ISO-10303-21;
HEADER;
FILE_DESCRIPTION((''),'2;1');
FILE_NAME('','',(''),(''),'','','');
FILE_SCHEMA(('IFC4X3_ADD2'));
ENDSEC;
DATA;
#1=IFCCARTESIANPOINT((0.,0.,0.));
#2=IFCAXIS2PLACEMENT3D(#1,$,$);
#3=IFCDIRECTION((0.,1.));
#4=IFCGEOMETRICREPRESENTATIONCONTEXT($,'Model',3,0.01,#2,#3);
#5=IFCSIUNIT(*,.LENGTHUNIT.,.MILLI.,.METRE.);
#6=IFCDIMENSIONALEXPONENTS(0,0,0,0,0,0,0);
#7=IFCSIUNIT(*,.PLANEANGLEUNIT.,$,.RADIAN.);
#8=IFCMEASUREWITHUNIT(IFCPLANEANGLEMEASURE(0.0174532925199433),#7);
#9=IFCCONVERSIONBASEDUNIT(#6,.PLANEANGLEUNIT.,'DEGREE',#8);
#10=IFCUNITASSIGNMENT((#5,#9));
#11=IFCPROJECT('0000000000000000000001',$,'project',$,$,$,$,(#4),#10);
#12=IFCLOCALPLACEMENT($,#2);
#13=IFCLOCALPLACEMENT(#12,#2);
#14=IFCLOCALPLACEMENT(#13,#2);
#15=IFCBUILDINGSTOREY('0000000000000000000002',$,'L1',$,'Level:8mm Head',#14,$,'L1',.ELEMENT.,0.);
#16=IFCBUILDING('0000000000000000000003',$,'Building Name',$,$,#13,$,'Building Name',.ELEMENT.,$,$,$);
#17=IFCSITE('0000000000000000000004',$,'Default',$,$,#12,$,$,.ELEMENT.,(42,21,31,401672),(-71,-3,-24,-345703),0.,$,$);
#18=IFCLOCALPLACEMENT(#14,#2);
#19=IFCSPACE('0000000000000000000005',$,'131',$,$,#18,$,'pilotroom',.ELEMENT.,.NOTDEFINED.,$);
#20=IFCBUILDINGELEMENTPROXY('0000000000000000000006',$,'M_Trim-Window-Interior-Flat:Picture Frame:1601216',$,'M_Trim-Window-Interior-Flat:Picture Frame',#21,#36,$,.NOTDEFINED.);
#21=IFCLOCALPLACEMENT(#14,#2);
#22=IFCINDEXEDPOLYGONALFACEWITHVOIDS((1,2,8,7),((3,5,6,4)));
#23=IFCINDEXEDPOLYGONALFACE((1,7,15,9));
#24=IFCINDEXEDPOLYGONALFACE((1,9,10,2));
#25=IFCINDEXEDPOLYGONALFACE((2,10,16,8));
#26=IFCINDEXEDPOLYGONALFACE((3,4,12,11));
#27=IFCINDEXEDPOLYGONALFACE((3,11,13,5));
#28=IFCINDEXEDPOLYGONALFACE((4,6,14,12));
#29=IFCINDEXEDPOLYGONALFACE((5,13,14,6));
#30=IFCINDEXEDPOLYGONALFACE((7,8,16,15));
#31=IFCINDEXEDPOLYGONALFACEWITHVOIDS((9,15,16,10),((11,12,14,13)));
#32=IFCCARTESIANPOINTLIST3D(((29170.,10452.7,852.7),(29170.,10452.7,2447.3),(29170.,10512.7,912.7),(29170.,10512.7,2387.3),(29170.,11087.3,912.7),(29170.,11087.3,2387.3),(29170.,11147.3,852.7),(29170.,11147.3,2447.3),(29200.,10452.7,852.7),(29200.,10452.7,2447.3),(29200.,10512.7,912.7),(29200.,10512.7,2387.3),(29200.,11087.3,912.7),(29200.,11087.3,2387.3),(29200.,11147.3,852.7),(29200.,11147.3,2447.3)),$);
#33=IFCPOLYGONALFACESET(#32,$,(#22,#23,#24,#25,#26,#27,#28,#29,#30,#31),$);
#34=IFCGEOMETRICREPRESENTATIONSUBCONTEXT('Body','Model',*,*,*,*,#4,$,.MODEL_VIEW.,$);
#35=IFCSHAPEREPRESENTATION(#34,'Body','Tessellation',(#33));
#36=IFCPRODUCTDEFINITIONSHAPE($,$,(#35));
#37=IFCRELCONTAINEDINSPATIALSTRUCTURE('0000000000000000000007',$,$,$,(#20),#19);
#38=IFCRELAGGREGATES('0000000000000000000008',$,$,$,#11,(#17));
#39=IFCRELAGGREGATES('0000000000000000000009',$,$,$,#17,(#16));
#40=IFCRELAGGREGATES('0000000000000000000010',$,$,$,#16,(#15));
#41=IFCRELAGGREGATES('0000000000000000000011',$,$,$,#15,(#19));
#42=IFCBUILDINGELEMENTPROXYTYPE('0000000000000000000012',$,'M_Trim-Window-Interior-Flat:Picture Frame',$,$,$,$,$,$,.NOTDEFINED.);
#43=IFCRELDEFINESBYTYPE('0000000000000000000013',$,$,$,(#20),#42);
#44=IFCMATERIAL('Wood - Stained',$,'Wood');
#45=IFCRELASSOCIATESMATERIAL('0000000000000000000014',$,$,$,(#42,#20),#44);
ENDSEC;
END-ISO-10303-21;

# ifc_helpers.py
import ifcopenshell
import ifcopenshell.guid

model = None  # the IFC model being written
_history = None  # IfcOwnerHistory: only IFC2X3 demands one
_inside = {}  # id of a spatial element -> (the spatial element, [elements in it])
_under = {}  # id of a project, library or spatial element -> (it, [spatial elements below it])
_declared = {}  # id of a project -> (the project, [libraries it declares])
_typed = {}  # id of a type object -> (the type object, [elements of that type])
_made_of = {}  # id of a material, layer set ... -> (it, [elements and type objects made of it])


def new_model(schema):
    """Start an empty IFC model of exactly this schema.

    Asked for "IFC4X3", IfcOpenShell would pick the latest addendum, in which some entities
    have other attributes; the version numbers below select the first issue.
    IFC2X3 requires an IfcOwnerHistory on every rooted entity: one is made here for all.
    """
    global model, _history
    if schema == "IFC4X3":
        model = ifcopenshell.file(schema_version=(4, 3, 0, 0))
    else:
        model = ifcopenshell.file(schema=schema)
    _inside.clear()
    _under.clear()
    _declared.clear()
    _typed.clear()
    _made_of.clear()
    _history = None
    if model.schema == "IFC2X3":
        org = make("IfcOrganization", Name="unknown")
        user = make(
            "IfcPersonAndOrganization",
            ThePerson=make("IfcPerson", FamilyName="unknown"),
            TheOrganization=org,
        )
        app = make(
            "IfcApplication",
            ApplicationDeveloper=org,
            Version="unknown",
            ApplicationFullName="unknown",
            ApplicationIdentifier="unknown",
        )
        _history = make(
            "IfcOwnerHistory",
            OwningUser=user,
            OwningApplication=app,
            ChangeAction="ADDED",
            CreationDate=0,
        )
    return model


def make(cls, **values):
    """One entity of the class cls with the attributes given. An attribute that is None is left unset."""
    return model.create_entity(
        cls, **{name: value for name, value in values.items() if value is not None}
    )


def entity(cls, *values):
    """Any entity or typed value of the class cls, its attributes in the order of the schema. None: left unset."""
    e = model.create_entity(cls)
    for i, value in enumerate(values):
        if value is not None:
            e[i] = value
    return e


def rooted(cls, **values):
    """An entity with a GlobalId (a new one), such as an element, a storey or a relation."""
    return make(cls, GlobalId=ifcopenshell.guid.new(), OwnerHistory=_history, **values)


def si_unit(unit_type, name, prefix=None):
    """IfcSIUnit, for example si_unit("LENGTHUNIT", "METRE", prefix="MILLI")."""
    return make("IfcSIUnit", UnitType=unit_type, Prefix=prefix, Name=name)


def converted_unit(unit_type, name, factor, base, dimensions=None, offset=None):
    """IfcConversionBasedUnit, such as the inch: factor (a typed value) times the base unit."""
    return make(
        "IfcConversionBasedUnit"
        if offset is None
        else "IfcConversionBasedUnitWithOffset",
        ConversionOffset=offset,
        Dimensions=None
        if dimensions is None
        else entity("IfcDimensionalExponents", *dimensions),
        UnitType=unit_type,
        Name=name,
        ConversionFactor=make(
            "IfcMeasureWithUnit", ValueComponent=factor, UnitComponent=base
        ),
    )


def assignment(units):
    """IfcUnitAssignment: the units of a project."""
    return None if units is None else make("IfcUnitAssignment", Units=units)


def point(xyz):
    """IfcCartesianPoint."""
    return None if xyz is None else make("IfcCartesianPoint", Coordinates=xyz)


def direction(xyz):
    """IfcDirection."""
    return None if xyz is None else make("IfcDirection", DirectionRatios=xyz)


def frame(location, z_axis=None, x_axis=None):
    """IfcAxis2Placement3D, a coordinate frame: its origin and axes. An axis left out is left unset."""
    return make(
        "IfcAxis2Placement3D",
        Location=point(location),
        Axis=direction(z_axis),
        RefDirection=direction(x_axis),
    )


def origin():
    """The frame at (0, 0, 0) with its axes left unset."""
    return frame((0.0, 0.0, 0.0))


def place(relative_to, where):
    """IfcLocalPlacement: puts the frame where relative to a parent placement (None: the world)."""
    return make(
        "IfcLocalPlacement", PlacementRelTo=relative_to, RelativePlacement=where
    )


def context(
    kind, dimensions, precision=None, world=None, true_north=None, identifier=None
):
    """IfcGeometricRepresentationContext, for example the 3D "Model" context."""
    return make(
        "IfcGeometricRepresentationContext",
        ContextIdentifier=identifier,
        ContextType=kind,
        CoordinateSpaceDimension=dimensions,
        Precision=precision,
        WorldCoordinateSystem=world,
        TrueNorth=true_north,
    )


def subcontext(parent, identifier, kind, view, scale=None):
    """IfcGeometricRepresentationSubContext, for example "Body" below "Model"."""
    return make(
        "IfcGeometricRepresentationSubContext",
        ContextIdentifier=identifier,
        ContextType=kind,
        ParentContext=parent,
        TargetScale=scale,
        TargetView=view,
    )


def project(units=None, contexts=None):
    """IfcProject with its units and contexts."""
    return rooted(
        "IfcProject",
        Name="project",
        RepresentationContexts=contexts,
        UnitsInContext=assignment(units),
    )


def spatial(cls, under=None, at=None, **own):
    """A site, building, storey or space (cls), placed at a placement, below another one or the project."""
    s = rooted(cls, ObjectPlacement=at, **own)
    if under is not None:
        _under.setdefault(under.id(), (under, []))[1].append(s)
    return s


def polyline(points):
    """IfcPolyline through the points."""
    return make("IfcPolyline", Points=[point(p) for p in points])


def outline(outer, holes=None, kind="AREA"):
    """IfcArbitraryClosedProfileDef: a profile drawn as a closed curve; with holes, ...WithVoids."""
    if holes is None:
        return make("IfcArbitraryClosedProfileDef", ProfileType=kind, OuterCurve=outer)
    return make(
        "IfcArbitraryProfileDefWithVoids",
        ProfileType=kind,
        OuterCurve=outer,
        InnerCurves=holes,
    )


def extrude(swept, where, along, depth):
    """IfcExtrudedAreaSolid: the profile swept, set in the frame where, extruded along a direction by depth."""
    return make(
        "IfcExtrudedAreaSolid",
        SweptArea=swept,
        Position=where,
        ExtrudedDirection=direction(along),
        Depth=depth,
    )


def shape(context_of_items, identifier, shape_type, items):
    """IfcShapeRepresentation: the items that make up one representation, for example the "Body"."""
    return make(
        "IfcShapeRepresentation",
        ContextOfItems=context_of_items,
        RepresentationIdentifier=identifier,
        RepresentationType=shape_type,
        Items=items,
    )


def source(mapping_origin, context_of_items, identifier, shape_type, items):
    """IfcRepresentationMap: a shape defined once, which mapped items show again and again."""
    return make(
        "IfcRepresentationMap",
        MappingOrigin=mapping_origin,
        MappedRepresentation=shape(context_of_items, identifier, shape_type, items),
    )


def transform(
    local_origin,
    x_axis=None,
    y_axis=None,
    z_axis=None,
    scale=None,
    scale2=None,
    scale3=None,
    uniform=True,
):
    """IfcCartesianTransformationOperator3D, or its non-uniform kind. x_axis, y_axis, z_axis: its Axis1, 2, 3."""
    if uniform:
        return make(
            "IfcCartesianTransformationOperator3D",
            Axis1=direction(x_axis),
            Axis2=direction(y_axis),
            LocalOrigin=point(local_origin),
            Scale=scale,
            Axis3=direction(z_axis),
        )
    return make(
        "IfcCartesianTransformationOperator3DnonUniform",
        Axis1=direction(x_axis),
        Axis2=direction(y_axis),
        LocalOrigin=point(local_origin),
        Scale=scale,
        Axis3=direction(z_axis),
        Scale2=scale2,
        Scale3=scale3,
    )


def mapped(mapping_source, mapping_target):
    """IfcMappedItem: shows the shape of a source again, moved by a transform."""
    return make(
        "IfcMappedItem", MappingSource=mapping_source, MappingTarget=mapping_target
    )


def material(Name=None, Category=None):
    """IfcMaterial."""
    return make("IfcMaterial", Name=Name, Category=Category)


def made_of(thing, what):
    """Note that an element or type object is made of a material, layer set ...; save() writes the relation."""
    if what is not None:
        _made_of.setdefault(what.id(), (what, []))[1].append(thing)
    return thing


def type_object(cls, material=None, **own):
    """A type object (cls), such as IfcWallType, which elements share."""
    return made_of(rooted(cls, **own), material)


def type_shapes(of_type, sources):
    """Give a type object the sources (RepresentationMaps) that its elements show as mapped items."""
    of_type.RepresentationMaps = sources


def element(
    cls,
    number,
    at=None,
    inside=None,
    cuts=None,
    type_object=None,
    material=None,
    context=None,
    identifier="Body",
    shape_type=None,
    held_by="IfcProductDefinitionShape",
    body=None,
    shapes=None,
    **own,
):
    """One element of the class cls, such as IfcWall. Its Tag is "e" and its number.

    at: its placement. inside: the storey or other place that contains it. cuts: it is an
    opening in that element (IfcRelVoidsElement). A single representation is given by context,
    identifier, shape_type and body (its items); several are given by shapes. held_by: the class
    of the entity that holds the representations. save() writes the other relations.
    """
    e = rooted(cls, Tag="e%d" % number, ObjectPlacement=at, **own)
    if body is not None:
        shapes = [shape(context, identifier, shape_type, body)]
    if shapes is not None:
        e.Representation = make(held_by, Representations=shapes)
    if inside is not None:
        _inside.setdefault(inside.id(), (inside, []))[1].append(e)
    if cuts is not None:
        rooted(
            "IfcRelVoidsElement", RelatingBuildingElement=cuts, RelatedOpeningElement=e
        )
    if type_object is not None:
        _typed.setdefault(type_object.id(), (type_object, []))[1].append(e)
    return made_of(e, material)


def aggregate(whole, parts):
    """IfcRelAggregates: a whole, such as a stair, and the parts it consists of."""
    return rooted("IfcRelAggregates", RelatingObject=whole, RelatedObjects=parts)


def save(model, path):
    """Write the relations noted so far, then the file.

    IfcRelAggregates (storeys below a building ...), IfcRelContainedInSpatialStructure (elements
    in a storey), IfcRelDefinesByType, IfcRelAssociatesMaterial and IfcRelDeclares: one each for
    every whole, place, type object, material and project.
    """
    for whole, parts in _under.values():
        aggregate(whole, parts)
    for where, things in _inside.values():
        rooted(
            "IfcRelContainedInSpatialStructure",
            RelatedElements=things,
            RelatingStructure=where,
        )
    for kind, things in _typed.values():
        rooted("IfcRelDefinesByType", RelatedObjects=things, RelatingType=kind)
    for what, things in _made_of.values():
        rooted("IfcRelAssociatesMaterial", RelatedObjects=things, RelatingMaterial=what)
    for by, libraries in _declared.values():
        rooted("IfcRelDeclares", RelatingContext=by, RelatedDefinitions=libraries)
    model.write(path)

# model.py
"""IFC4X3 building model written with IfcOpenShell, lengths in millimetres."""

from ifc_helpers import new_model, entity, si_unit, converted_unit, direction, frame, origin, place, context, subcontext, project, spatial, polyline, outline, extrude, source, transform, mapped, material, type_object, type_shapes, element, save


model = new_model("IFC4X3")

# Units and contexts
model_context = context("Model", 3, precision=0.01, world=origin(), true_north=direction((0.0, 1.0)))
body_context = subcontext(model_context, "Body", "Model", "MODEL_VIEW")
ifc_project = project(units=[si_unit("LENGTHUNIT", "METRE", prefix="MILLI"), converted_unit("PLANEANGLEUNIT", "DEGREE", entity("IfcPlaneAngleMeasure", 0.0174532925199433), si_unit("PLANEANGLEUNIT", "RADIAN"), dimensions=[0, 0, 0, 0, 0, 0, 0])], contexts=[model_context])

# Site, building, storey, space
site_placement = place(None, origin())
site = spatial("IfcSite", under=ifc_project, at=site_placement, Name="Default", CompositionType="ELEMENT", RefLatitude=(42, 21, 31, 401672), RefLongitude=(-71, -3, -24, -345703), RefElevation=0.0)
building_placement = place(site_placement, origin())
building = spatial("IfcBuilding", under=site, at=building_placement, Name="Building Name", LongName="Building Name", CompositionType="ELEMENT")
storey_placement = place(building_placement, origin())
storey = spatial("IfcBuildingStorey", under=building, at=storey_placement, Name="L1", ObjectType="Level:8mm Head", LongName="L1", CompositionType="ELEMENT", Elevation=0.0)
space_placement = place(storey_placement, origin())
space = spatial("IfcSpace", under=storey, at=space_placement, Name="131", LongName="pilotroom", CompositionType="ELEMENT", PredefinedType="NOTDEFINED")

# Building element proxy
ifc_material = material(Name="Wood - Stained", Category="Wood")
building_element_proxy_type = type_object("IfcBuildingElementProxyType", Name="M_Trim-Window-Interior-Flat:Picture Frame", PredefinedType="NOTDEFINED", material=ifc_material)
shared_shape = source(origin(), body_context, "Body", "SweptSolid", [
    extrude(outline(polyline([(-347.3, -797.3), (347.3, -797.3), (347.3, 797.3), (-347.3, 797.3), (-347.3, -797.3)]), holes=[polyline([(-287.3, -737.3), (-287.3, 737.3), (287.3, 737.3), (287.3, -737.3), (-287.3, -737.3)])]), frame((0.0, -750.0, 0.0), z_axis=(0.0, 0.0, 1.0), x_axis=(-1.0, 0.0, 0.0)), (0.0, 0.0, 1.0), 30.0),
])
type_shapes(building_element_proxy_type, [shared_shape])
proxy_placement = place(space_placement, frame((29200.0, 10800.0, 2400.0), z_axis=(-1.0, 0.0, 0.0), x_axis=(0.0, -1.0, 0.0)))
element("IfcBuildingElementProxy", 1, at=proxy_placement, inside=space, type_object=building_element_proxy_type, material=ifc_material, Name="M_Trim-Window-Interior-Flat:Picture Frame:1601216", ObjectType="M_Trim-Window-Interior-Flat:Picture Frame", PredefinedType="NOTDEFINED", context=body_context, shape_type="MappedRepresentation", body=[
    mapped(shared_shape, transform((0.0, 0.0, 0.0), scale=1.0)),
])

save(model, "model.ifc")
